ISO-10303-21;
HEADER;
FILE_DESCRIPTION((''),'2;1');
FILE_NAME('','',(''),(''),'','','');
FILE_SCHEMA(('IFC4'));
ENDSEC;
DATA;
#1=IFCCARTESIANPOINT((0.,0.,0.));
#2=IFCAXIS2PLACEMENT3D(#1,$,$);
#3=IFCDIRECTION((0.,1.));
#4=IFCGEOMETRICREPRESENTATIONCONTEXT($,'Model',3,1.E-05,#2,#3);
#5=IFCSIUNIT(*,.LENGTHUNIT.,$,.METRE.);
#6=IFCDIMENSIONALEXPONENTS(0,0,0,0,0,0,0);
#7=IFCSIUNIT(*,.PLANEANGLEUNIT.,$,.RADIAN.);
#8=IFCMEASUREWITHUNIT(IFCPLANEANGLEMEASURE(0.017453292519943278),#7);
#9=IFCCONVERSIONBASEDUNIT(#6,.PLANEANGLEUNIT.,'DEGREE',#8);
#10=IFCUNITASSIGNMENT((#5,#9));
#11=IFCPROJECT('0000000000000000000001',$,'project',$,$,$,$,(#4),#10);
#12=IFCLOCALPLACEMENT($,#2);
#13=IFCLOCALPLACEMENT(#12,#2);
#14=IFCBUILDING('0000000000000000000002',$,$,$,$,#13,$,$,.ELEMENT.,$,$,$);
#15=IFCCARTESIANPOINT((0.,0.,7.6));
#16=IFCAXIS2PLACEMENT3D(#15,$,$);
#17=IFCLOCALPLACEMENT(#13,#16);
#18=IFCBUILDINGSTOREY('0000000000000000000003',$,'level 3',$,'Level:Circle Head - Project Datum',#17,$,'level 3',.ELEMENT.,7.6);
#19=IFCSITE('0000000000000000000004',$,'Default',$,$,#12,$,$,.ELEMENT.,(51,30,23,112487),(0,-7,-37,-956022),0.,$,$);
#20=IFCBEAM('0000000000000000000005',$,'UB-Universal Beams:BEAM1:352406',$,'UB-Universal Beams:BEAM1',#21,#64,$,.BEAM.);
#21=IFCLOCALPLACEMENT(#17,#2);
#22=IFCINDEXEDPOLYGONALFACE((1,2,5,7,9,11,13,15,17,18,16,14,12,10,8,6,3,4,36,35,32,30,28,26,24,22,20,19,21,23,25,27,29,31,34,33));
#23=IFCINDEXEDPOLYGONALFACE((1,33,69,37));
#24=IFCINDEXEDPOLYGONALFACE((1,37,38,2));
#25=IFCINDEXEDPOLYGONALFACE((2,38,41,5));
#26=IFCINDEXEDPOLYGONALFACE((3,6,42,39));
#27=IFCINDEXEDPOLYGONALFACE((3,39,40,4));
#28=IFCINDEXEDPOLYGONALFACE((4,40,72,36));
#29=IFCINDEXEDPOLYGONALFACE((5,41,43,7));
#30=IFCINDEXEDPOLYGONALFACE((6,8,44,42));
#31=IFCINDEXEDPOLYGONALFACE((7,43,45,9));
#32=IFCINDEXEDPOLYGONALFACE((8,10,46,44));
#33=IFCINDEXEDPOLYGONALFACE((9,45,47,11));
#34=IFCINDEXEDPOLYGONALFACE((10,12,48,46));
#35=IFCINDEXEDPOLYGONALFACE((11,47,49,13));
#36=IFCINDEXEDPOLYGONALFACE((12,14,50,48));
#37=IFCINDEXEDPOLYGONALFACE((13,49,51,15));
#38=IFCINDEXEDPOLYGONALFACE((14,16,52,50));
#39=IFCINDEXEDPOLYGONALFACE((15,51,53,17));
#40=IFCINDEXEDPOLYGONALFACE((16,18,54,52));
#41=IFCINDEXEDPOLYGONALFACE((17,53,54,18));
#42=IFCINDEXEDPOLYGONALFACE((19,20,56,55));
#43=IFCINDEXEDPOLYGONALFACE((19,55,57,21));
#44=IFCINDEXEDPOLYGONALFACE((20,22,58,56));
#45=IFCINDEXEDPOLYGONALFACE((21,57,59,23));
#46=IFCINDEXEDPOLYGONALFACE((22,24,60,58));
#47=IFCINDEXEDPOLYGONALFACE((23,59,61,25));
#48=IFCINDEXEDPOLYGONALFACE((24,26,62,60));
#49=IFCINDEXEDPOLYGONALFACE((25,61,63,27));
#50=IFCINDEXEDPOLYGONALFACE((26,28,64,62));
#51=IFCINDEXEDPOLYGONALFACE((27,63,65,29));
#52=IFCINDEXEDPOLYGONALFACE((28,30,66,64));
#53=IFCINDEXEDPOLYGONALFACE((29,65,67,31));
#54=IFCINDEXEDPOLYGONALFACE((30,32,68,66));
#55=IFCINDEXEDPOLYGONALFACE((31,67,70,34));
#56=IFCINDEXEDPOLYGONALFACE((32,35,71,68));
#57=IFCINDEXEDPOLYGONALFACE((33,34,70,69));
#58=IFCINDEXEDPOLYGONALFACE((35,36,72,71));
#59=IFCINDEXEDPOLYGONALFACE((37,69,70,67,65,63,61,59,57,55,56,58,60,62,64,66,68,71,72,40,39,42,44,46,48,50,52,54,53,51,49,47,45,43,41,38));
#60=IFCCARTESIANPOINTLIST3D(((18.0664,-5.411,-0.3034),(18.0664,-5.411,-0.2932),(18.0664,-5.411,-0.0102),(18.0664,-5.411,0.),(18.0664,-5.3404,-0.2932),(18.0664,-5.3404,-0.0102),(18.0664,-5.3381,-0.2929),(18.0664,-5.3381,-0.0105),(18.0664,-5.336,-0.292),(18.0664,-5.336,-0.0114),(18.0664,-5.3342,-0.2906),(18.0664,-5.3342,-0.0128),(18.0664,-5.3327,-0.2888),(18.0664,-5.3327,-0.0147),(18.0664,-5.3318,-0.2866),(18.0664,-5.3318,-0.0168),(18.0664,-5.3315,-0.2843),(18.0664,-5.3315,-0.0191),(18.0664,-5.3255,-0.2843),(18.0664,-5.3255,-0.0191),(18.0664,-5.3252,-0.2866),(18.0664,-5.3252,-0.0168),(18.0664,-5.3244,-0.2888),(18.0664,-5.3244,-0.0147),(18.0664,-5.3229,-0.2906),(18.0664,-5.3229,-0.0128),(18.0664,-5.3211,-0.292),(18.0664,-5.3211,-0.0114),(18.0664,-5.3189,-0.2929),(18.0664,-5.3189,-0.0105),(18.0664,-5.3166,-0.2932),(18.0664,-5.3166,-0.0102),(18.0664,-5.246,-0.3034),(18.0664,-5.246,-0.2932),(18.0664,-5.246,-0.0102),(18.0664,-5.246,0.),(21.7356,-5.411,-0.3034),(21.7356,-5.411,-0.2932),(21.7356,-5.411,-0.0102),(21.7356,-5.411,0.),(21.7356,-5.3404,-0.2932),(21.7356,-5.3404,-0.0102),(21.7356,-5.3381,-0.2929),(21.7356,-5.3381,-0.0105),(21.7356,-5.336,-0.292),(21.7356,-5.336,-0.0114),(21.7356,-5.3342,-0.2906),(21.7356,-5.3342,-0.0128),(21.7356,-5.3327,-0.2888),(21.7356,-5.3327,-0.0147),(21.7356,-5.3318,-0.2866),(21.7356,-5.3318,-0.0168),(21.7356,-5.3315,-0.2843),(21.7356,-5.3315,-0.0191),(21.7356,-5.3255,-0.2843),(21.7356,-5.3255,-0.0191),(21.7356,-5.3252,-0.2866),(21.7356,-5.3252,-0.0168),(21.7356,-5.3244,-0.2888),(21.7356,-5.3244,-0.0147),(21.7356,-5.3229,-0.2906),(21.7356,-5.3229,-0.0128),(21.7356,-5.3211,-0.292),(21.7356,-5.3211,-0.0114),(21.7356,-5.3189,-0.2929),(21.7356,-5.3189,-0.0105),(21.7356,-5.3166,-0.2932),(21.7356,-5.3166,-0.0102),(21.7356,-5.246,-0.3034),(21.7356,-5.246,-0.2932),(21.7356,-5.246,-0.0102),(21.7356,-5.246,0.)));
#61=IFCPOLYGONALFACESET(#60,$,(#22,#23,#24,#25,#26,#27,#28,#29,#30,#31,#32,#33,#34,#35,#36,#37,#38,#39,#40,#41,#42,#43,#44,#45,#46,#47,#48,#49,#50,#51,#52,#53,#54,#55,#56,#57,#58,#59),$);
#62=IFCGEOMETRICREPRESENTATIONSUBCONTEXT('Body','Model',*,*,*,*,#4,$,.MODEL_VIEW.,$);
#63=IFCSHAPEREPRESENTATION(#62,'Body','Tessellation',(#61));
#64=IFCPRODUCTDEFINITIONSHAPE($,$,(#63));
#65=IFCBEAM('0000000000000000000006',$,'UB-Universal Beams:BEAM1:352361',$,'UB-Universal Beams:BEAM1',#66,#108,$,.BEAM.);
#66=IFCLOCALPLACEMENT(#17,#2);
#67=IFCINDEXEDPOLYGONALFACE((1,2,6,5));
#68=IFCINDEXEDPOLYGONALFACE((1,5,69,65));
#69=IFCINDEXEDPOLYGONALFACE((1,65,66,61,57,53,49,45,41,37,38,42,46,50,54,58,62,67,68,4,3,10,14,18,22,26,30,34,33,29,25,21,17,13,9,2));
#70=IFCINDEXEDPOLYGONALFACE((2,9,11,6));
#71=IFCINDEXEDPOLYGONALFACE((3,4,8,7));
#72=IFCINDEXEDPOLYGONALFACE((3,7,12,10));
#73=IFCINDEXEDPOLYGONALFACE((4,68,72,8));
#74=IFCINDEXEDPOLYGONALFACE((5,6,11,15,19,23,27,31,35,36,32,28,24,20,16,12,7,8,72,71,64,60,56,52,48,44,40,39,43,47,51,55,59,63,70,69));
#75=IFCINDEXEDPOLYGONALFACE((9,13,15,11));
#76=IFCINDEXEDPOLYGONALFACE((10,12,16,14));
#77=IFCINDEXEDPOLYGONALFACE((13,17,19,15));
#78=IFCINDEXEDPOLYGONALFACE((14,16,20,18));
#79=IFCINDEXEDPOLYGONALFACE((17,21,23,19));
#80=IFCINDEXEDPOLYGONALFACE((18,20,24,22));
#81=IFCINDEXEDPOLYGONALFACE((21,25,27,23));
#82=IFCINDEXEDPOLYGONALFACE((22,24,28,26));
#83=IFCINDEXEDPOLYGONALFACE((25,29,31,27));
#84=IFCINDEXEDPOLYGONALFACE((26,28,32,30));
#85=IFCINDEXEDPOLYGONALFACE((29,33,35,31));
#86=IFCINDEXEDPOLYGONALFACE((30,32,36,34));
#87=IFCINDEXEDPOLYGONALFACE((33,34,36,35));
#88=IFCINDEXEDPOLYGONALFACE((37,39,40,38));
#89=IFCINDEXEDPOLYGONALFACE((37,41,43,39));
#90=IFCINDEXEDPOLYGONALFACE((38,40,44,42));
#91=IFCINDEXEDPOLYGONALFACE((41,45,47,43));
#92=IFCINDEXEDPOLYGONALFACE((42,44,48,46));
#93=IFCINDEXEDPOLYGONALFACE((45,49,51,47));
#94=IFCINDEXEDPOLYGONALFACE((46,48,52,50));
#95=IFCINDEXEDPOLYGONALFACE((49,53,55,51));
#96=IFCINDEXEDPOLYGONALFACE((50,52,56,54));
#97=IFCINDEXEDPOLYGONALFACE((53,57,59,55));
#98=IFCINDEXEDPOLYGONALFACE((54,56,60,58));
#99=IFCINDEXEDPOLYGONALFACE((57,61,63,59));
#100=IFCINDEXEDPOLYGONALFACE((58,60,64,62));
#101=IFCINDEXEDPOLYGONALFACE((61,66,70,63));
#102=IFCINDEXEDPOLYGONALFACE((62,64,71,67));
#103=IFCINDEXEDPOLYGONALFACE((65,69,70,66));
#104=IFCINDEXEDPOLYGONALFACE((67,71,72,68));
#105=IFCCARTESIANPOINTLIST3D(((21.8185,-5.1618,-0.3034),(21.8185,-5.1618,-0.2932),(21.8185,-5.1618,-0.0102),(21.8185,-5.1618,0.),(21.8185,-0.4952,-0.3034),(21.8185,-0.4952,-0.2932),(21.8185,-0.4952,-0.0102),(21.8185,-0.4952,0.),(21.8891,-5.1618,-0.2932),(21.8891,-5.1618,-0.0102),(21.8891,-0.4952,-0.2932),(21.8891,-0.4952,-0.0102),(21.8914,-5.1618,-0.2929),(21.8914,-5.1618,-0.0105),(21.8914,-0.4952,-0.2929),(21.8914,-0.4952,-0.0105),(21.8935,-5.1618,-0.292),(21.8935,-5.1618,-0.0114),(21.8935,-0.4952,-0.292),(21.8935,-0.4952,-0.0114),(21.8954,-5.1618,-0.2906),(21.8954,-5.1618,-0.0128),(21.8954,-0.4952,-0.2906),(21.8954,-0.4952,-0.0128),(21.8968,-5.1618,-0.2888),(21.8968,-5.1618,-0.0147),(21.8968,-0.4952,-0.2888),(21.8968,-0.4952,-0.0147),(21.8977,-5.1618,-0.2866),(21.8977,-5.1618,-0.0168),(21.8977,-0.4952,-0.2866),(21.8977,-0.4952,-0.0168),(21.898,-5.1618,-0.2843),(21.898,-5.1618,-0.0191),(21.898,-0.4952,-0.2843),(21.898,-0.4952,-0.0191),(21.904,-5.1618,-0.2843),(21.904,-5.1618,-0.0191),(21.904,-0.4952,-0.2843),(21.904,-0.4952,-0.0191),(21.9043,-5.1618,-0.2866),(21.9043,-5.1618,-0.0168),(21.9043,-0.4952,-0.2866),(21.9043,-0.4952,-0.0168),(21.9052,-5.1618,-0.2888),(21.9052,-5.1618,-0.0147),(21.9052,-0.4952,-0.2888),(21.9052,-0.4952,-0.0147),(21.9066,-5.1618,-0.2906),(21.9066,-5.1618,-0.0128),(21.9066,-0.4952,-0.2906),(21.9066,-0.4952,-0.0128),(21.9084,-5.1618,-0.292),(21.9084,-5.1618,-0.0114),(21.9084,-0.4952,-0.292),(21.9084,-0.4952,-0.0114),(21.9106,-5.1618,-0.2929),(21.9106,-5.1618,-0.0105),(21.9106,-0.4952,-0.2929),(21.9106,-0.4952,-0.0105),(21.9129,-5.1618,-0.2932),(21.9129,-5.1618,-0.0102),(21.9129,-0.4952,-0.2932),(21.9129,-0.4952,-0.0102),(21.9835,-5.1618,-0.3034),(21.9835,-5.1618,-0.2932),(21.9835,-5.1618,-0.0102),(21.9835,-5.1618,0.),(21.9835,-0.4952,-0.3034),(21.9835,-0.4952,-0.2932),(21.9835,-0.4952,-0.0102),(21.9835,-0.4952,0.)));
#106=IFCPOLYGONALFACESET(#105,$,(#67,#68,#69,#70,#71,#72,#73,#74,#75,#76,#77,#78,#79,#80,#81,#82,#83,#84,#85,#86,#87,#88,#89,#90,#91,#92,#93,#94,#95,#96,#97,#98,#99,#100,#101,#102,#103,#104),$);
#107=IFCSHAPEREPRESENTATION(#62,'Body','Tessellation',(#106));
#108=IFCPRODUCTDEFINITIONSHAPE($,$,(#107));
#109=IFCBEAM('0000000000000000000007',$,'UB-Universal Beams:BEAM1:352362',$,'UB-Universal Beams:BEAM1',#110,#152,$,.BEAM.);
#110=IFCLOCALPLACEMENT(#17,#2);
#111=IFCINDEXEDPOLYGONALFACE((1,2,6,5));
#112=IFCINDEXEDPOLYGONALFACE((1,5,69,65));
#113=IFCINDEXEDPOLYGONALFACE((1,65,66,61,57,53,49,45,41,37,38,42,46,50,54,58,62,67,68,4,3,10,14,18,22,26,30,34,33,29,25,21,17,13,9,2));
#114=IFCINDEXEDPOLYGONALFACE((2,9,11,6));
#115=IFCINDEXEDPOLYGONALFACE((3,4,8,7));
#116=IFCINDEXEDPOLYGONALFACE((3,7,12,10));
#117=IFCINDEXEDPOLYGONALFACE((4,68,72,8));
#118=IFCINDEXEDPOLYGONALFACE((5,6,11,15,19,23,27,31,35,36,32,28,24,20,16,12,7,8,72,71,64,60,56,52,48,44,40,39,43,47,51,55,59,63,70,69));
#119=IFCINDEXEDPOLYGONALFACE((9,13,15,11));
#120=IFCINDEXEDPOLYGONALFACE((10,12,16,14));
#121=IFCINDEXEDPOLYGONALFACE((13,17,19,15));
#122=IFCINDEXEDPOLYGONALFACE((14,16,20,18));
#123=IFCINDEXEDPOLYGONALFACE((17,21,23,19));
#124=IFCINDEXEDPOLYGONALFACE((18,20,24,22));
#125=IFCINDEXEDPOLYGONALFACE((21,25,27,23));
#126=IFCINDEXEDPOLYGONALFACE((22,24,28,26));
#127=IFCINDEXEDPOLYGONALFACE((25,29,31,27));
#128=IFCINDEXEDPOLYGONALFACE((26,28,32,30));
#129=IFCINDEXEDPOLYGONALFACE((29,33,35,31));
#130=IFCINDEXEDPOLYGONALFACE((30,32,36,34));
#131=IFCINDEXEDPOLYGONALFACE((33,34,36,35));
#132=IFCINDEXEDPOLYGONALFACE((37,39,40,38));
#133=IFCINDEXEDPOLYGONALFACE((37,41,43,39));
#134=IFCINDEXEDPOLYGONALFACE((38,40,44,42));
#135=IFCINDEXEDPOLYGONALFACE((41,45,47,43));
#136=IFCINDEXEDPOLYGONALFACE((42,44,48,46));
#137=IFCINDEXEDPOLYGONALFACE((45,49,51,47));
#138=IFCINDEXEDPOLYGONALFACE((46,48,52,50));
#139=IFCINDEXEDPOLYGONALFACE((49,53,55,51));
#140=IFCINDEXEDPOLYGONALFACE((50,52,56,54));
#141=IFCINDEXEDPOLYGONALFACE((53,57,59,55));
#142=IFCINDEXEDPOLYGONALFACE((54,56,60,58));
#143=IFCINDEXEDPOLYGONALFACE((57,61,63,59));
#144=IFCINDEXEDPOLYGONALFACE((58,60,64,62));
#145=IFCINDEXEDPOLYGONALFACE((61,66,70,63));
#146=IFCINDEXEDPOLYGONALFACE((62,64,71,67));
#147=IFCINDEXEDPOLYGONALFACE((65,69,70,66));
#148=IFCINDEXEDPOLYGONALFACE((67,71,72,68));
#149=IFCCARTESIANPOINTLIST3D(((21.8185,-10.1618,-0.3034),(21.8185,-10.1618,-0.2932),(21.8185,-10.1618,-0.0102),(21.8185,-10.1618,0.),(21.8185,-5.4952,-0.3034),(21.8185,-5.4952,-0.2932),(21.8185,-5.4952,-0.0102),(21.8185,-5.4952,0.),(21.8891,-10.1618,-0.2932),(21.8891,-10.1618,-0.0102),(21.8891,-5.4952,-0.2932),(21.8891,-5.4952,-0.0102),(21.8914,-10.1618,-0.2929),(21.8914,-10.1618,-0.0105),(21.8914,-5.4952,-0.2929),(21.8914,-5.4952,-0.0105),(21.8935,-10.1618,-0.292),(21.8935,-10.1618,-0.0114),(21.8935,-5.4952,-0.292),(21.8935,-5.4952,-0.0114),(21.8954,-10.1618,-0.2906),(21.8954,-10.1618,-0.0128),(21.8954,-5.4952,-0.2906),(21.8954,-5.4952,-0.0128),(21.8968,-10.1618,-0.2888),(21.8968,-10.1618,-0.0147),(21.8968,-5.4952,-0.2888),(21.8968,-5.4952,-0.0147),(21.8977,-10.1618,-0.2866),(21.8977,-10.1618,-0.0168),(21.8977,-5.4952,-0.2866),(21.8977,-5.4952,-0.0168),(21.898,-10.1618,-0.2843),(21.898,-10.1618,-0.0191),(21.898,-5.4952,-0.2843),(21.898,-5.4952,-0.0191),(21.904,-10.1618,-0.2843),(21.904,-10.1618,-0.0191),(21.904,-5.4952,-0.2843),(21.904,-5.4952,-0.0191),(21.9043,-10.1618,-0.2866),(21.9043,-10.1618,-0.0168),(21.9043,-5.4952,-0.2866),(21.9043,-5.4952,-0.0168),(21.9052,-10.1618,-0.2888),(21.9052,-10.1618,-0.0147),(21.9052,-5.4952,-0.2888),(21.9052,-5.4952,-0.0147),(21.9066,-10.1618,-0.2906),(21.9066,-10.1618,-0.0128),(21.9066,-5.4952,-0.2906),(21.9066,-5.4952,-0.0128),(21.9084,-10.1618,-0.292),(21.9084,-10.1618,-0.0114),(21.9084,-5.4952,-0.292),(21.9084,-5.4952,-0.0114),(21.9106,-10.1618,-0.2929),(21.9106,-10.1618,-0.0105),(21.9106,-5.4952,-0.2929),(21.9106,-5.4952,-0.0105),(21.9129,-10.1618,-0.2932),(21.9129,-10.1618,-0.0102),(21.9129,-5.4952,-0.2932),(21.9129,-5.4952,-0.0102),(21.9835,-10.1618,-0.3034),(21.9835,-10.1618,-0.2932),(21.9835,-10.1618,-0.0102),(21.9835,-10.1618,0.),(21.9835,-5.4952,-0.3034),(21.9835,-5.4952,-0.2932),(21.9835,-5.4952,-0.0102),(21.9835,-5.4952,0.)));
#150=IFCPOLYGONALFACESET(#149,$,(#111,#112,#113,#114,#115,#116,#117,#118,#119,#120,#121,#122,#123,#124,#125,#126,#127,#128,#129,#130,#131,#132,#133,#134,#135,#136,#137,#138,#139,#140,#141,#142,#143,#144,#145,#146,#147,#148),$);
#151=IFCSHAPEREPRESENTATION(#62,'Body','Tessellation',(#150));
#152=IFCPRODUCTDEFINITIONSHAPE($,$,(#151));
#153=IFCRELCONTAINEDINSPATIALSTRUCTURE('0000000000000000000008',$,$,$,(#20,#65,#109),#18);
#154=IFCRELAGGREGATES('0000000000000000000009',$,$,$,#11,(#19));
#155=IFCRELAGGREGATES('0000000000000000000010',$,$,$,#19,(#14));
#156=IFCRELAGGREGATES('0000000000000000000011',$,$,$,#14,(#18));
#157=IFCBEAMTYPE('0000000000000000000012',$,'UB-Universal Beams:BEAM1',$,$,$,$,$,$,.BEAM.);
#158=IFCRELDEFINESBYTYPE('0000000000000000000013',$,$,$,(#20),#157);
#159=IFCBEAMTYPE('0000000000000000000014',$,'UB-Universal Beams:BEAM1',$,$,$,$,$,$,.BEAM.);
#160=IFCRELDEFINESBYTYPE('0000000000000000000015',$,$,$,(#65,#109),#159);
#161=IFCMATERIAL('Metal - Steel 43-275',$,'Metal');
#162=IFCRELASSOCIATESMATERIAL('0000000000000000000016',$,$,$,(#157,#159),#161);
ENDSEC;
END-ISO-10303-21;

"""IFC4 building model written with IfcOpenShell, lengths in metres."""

from ifc_helpers import new_model, entity, si_unit, converted_unit, direction, frame, frame_2d, origin, place, context, subcontext, project, spatial, polyline, circle_curve, parameter, trimmed, segment, composite_curve, outline, extrude, source, transform, mapped, material, material_profile, profile_set, type_object, type_shapes, element, save


model = new_model("IFC4")

# Units and contexts
model_context = context("Model", 3, precision=1e-05, world=origin(), true_north=direction((0.0, 1.0)))
body_context = subcontext(model_context, "Body", "Model", "MODEL_VIEW")
ifc_project = project(units=[si_unit("LENGTHUNIT", "METRE"), converted_unit("PLANEANGLEUNIT", "DEGREE", entity("IfcPlaneAngleMeasure", 0.017453292519943278), si_unit("PLANEANGLEUNIT", "RADIAN"), dimensions=[0, 0, 0, 0, 0, 0, 0])], contexts=[model_context])

# Site, building, storey
site_placement = place(None, origin())
site = spatial("IfcSite", under=ifc_project, at=site_placement, Name="Default", CompositionType="ELEMENT", RefLatitude=(51, 30, 23, 112487), RefLongitude=(0, -7, -37, -956022), RefElevation=0.0)
building_placement = place(site_placement, origin())
building = spatial("IfcBuilding", under=site, at=building_placement, CompositionType="ELEMENT")
storey_placement = place(building_placement, frame((0.0, 0.0, 7.6)))
storey = spatial("IfcBuildingStorey", under=building, at=storey_placement, Name="level 3", ObjectType="Level:Circle Head - Project Datum", LongName="level 3", CompositionType="ELEMENT", Elevation=7.6)

# Shared definitions
ifc_material_1 = material(Name="Metal - Steel 43-275", Category="Metal")

# Beams
ifc_material_profile_1 = material_profile(ifc_material_1, outline(composite_curve([segment(polyline([(-0.0825, -0.1415), (-0.0825, -0.1517)]), True, "CONTINUOUS"), segment(polyline([(-0.0825, -0.1517), (0.0825, -0.1517)]), True, "CONTINUOUS"), segment(polyline([(0.0825, -0.1517), (0.0825, -0.1415)]), True, "CONTINUOUS"), segment(polyline([(0.0825, -0.1415), (0.0119, -0.1415)]), True, "CONTINUOUS"), segment(trimmed(circle_curve(frame_2d((0.0119, -0.1326), x_axis=(1.0, 0.0)), 0.0089), [parameter(180.0)], [parameter(270.0)], True, "PARAMETER"), False, "CONTINUOUS"), segment(polyline([(0.003, -0.1326), (0.003, 0.1326)]), True, "CONTINUOUS"), segment(trimmed(circle_curve(frame_2d((0.0119, 0.1326), x_axis=(1.0, 0.0)), 0.0089), [parameter(90.0)], [parameter(180.0)], True, "PARAMETER"), False, "CONTINUOUS"), segment(polyline([(0.0119, 0.1415), (0.0825, 0.1415)]), True, "CONTINUOUS"), segment(polyline([(0.0825, 0.1415), (0.0825, 0.1517)]), True, "CONTINUOUS"), segment(polyline([(0.0825, 0.1517), (-0.0825, 0.1517)]), True, "CONTINUOUS"), segment(polyline([(-0.0825, 0.1517), (-0.0825, 0.1415)]), True, "CONTINUOUS"), segment(polyline([(-0.0825, 0.1415), (-0.0119, 0.1415)]), True, "CONTINUOUS"), segment(trimmed(circle_curve(frame_2d((-0.0119, 0.1326), x_axis=(1.0, 0.0)), 0.0089), [parameter(360.0)], [parameter(90.0)], True, "PARAMETER"), False, "CONTINUOUS"), segment(polyline([(-0.003, 0.1326), (-0.003, -0.1326)]), True, "CONTINUOUS"), segment(trimmed(circle_curve(frame_2d((-0.0119, -0.1326), x_axis=(1.0, 0.0)), 0.0089), [parameter(270.0)], [parameter(360.0)], True, "PARAMETER"), False, "CONTINUOUS"), segment(polyline([(-0.0119, -0.1415), (-0.0825, -0.1415)]), True, "CONTINUOUS")], self_intersect=False)), Name="BEAM1")
ifc_profile_set_1 = profile_set([ifc_material_profile_1], Name="BEAM1")
beam_type_1 = type_object("IfcBeamType", Name="UB-Universal Beams:BEAM1", PredefinedType="BEAM", material=ifc_profile_set_1)
shared_shape_1 = source(origin(), body_context, "Body", "SweptSolid", [
    extrude(outline(composite_curve([segment(polyline([(-0.0825, -0.1415), (-0.0825, -0.1517)]), True, "CONTINUOUS"), segment(polyline([(-0.0825, -0.1517), (0.0825, -0.1517)]), True, "CONTINUOUS"), segment(polyline([(0.0825, -0.1517), (0.0825, -0.1415)]), True, "CONTINUOUS"), segment(polyline([(0.0825, -0.1415), (0.0119, -0.1415)]), True, "CONTINUOUS"), segment(trimmed(circle_curve(frame_2d((0.0119, -0.1326), x_axis=(0.0, -1.0)), 0.0089), [parameter(270.0)], [parameter(360.0)], True, "PARAMETER"), False, "CONTINUOUS"), segment(polyline([(0.003, -0.1326), (0.003, 0.1326)]), True, "CONTINUOUS"), segment(trimmed(circle_curve(frame_2d((0.0119, 0.1326), x_axis=(-1.0, 0.0)), 0.0089), [parameter(270.0)], [parameter(360.0)], True, "PARAMETER"), False, "CONTINUOUS"), segment(polyline([(0.0119, 0.1415), (0.0825, 0.1415)]), True, "CONTINUOUS"), segment(polyline([(0.0825, 0.1415), (0.0825, 0.1517)]), True, "CONTINUOUS"), segment(polyline([(0.0825, 0.1517), (-0.0825, 0.1517)]), True, "CONTINUOUS"), segment(polyline([(-0.0825, 0.1517), (-0.0825, 0.1415)]), True, "CONTINUOUS"), segment(polyline([(-0.0825, 0.1415), (-0.0119, 0.1415)]), True, "CONTINUOUS"), segment(trimmed(circle_curve(frame_2d((-0.0119, 0.1326), x_axis=(0.0, 1.0)), 0.0089), [parameter(270.0)], [parameter(360.0)], True, "PARAMETER"), False, "CONTINUOUS"), segment(polyline([(-0.003, 0.1326), (-0.003, -0.1326)]), True, "CONTINUOUS"), segment(trimmed(circle_curve(frame_2d((-0.0119, -0.1326), x_axis=(1.0, 0.0)), 0.0089), [parameter(270.0)], [parameter(0.0)], True, "PARAMETER"), False, "CONTINUOUS"), segment(polyline([(-0.0119, -0.1415), (-0.0825, -0.1415)]), True, "CONTINUOUS")], self_intersect=False)), frame((-1.8346, 0.0, 0.0), z_axis=(-1.0, 0.0, 0.0), x_axis=(0.0, -1.0, 0.0)), (0.0, 0.0, -1.0), 3.6692),
])
type_shapes(beam_type_1, [shared_shape_1])
for number, where, name in (
    (1, (19.901, -5.3285, -0.1517), "UB-Universal Beams:BEAM1:352406"),
):
    element("IfcBeam", number, at=place(storey_placement, frame(where)), inside=storey, type_object=beam_type_1, Name=name, ObjectType="UB-Universal Beams:BEAM1", PredefinedType="BEAM", context=body_context, shape_type="MappedRepresentation", body=[
        mapped(shared_shape_1, transform((0.0, 0.0, 0.0), scale=1.0)),
    ])
beam_type_2 = type_object("IfcBeamType", Name="UB-Universal Beams:BEAM1", PredefinedType="BEAM", material=ifc_profile_set_1)
shared_shape_2 = source(origin(), body_context, "Body", "SweptSolid", [
    extrude(outline(composite_curve([segment(polyline([(-0.0825, -0.1415), (-0.0825, -0.1517)]), True, "CONTINUOUS"), segment(polyline([(-0.0825, -0.1517), (0.0825, -0.1517)]), True, "CONTINUOUS"), segment(polyline([(0.0825, -0.1517), (0.0825, -0.1415)]), True, "CONTINUOUS"), segment(polyline([(0.0825, -0.1415), (0.0119, -0.1415)]), True, "CONTINUOUS"), segment(trimmed(circle_curve(frame_2d((0.0119, -0.1326), x_axis=(0.0, -1.0)), 0.0089), [parameter(270.0)], [parameter(360.0)], True, "PARAMETER"), False, "CONTINUOUS"), segment(polyline([(0.003, -0.1326), (0.003, 0.1326)]), True, "CONTINUOUS"), segment(trimmed(circle_curve(frame_2d((0.0119, 0.1326), x_axis=(-1.0, 0.0)), 0.0089), [parameter(270.0)], [parameter(360.0)], True, "PARAMETER"), False, "CONTINUOUS"), segment(polyline([(0.0119, 0.1415), (0.0825, 0.1415)]), True, "CONTINUOUS"), segment(polyline([(0.0825, 0.1415), (0.0825, 0.1517)]), True, "CONTINUOUS"), segment(polyline([(0.0825, 0.1517), (-0.0825, 0.1517)]), True, "CONTINUOUS"), segment(polyline([(-0.0825, 0.1517), (-0.0825, 0.1415)]), True, "CONTINUOUS"), segment(polyline([(-0.0825, 0.1415), (-0.0119, 0.1415)]), True, "CONTINUOUS"), segment(trimmed(circle_curve(frame_2d((-0.0119, 0.1326), x_axis=(0.0, 1.0)), 0.0089), [parameter(270.0)], [parameter(360.0)], True, "PARAMETER"), False, "CONTINUOUS"), segment(polyline([(-0.003, 0.1326), (-0.003, -0.1326)]), True, "CONTINUOUS"), segment(trimmed(circle_curve(frame_2d((-0.0119, -0.1326), x_axis=(1.0, 0.0)), 0.0089), [parameter(270.0)], [parameter(0.0)], True, "PARAMETER"), False, "CONTINUOUS"), segment(polyline([(-0.0119, -0.1415), (-0.0825, -0.1415)]), True, "CONTINUOUS")], self_intersect=False)), frame((-2.3333, 0.0, 0.0), z_axis=(-1.0, 0.0, 0.0), x_axis=(0.0, -1.0, 0.0)), (0.0, 0.0, -1.0), 4.6666),
])
type_shapes(beam_type_2, [shared_shape_2])
for number, where, z_axis, x_axis, name in (
    (2, (21.901, -2.8285, -0.1517), (0.0, 0.0, 1.0), (0.0, -1.0, 0.0), "UB-Universal Beams:BEAM1:352361"),
    (3, (21.901, -7.8285, -0.1517), (0.0, 0.0, 1.0), (0.0, 1.0, 0.0), "UB-Universal Beams:BEAM1:352362"),
):
    element("IfcBeam", number, at=place(storey_placement, frame(where, z_axis=z_axis, x_axis=x_axis)), inside=storey, type_object=beam_type_2, Name=name, ObjectType="UB-Universal Beams:BEAM1", PredefinedType="BEAM", context=body_context, shape_type="MappedRepresentation", body=[
        mapped(shared_shape_2, transform((0.0, 0.0, 0.0), scale=1.0)),
    ])

save(model, "model.ifc")
